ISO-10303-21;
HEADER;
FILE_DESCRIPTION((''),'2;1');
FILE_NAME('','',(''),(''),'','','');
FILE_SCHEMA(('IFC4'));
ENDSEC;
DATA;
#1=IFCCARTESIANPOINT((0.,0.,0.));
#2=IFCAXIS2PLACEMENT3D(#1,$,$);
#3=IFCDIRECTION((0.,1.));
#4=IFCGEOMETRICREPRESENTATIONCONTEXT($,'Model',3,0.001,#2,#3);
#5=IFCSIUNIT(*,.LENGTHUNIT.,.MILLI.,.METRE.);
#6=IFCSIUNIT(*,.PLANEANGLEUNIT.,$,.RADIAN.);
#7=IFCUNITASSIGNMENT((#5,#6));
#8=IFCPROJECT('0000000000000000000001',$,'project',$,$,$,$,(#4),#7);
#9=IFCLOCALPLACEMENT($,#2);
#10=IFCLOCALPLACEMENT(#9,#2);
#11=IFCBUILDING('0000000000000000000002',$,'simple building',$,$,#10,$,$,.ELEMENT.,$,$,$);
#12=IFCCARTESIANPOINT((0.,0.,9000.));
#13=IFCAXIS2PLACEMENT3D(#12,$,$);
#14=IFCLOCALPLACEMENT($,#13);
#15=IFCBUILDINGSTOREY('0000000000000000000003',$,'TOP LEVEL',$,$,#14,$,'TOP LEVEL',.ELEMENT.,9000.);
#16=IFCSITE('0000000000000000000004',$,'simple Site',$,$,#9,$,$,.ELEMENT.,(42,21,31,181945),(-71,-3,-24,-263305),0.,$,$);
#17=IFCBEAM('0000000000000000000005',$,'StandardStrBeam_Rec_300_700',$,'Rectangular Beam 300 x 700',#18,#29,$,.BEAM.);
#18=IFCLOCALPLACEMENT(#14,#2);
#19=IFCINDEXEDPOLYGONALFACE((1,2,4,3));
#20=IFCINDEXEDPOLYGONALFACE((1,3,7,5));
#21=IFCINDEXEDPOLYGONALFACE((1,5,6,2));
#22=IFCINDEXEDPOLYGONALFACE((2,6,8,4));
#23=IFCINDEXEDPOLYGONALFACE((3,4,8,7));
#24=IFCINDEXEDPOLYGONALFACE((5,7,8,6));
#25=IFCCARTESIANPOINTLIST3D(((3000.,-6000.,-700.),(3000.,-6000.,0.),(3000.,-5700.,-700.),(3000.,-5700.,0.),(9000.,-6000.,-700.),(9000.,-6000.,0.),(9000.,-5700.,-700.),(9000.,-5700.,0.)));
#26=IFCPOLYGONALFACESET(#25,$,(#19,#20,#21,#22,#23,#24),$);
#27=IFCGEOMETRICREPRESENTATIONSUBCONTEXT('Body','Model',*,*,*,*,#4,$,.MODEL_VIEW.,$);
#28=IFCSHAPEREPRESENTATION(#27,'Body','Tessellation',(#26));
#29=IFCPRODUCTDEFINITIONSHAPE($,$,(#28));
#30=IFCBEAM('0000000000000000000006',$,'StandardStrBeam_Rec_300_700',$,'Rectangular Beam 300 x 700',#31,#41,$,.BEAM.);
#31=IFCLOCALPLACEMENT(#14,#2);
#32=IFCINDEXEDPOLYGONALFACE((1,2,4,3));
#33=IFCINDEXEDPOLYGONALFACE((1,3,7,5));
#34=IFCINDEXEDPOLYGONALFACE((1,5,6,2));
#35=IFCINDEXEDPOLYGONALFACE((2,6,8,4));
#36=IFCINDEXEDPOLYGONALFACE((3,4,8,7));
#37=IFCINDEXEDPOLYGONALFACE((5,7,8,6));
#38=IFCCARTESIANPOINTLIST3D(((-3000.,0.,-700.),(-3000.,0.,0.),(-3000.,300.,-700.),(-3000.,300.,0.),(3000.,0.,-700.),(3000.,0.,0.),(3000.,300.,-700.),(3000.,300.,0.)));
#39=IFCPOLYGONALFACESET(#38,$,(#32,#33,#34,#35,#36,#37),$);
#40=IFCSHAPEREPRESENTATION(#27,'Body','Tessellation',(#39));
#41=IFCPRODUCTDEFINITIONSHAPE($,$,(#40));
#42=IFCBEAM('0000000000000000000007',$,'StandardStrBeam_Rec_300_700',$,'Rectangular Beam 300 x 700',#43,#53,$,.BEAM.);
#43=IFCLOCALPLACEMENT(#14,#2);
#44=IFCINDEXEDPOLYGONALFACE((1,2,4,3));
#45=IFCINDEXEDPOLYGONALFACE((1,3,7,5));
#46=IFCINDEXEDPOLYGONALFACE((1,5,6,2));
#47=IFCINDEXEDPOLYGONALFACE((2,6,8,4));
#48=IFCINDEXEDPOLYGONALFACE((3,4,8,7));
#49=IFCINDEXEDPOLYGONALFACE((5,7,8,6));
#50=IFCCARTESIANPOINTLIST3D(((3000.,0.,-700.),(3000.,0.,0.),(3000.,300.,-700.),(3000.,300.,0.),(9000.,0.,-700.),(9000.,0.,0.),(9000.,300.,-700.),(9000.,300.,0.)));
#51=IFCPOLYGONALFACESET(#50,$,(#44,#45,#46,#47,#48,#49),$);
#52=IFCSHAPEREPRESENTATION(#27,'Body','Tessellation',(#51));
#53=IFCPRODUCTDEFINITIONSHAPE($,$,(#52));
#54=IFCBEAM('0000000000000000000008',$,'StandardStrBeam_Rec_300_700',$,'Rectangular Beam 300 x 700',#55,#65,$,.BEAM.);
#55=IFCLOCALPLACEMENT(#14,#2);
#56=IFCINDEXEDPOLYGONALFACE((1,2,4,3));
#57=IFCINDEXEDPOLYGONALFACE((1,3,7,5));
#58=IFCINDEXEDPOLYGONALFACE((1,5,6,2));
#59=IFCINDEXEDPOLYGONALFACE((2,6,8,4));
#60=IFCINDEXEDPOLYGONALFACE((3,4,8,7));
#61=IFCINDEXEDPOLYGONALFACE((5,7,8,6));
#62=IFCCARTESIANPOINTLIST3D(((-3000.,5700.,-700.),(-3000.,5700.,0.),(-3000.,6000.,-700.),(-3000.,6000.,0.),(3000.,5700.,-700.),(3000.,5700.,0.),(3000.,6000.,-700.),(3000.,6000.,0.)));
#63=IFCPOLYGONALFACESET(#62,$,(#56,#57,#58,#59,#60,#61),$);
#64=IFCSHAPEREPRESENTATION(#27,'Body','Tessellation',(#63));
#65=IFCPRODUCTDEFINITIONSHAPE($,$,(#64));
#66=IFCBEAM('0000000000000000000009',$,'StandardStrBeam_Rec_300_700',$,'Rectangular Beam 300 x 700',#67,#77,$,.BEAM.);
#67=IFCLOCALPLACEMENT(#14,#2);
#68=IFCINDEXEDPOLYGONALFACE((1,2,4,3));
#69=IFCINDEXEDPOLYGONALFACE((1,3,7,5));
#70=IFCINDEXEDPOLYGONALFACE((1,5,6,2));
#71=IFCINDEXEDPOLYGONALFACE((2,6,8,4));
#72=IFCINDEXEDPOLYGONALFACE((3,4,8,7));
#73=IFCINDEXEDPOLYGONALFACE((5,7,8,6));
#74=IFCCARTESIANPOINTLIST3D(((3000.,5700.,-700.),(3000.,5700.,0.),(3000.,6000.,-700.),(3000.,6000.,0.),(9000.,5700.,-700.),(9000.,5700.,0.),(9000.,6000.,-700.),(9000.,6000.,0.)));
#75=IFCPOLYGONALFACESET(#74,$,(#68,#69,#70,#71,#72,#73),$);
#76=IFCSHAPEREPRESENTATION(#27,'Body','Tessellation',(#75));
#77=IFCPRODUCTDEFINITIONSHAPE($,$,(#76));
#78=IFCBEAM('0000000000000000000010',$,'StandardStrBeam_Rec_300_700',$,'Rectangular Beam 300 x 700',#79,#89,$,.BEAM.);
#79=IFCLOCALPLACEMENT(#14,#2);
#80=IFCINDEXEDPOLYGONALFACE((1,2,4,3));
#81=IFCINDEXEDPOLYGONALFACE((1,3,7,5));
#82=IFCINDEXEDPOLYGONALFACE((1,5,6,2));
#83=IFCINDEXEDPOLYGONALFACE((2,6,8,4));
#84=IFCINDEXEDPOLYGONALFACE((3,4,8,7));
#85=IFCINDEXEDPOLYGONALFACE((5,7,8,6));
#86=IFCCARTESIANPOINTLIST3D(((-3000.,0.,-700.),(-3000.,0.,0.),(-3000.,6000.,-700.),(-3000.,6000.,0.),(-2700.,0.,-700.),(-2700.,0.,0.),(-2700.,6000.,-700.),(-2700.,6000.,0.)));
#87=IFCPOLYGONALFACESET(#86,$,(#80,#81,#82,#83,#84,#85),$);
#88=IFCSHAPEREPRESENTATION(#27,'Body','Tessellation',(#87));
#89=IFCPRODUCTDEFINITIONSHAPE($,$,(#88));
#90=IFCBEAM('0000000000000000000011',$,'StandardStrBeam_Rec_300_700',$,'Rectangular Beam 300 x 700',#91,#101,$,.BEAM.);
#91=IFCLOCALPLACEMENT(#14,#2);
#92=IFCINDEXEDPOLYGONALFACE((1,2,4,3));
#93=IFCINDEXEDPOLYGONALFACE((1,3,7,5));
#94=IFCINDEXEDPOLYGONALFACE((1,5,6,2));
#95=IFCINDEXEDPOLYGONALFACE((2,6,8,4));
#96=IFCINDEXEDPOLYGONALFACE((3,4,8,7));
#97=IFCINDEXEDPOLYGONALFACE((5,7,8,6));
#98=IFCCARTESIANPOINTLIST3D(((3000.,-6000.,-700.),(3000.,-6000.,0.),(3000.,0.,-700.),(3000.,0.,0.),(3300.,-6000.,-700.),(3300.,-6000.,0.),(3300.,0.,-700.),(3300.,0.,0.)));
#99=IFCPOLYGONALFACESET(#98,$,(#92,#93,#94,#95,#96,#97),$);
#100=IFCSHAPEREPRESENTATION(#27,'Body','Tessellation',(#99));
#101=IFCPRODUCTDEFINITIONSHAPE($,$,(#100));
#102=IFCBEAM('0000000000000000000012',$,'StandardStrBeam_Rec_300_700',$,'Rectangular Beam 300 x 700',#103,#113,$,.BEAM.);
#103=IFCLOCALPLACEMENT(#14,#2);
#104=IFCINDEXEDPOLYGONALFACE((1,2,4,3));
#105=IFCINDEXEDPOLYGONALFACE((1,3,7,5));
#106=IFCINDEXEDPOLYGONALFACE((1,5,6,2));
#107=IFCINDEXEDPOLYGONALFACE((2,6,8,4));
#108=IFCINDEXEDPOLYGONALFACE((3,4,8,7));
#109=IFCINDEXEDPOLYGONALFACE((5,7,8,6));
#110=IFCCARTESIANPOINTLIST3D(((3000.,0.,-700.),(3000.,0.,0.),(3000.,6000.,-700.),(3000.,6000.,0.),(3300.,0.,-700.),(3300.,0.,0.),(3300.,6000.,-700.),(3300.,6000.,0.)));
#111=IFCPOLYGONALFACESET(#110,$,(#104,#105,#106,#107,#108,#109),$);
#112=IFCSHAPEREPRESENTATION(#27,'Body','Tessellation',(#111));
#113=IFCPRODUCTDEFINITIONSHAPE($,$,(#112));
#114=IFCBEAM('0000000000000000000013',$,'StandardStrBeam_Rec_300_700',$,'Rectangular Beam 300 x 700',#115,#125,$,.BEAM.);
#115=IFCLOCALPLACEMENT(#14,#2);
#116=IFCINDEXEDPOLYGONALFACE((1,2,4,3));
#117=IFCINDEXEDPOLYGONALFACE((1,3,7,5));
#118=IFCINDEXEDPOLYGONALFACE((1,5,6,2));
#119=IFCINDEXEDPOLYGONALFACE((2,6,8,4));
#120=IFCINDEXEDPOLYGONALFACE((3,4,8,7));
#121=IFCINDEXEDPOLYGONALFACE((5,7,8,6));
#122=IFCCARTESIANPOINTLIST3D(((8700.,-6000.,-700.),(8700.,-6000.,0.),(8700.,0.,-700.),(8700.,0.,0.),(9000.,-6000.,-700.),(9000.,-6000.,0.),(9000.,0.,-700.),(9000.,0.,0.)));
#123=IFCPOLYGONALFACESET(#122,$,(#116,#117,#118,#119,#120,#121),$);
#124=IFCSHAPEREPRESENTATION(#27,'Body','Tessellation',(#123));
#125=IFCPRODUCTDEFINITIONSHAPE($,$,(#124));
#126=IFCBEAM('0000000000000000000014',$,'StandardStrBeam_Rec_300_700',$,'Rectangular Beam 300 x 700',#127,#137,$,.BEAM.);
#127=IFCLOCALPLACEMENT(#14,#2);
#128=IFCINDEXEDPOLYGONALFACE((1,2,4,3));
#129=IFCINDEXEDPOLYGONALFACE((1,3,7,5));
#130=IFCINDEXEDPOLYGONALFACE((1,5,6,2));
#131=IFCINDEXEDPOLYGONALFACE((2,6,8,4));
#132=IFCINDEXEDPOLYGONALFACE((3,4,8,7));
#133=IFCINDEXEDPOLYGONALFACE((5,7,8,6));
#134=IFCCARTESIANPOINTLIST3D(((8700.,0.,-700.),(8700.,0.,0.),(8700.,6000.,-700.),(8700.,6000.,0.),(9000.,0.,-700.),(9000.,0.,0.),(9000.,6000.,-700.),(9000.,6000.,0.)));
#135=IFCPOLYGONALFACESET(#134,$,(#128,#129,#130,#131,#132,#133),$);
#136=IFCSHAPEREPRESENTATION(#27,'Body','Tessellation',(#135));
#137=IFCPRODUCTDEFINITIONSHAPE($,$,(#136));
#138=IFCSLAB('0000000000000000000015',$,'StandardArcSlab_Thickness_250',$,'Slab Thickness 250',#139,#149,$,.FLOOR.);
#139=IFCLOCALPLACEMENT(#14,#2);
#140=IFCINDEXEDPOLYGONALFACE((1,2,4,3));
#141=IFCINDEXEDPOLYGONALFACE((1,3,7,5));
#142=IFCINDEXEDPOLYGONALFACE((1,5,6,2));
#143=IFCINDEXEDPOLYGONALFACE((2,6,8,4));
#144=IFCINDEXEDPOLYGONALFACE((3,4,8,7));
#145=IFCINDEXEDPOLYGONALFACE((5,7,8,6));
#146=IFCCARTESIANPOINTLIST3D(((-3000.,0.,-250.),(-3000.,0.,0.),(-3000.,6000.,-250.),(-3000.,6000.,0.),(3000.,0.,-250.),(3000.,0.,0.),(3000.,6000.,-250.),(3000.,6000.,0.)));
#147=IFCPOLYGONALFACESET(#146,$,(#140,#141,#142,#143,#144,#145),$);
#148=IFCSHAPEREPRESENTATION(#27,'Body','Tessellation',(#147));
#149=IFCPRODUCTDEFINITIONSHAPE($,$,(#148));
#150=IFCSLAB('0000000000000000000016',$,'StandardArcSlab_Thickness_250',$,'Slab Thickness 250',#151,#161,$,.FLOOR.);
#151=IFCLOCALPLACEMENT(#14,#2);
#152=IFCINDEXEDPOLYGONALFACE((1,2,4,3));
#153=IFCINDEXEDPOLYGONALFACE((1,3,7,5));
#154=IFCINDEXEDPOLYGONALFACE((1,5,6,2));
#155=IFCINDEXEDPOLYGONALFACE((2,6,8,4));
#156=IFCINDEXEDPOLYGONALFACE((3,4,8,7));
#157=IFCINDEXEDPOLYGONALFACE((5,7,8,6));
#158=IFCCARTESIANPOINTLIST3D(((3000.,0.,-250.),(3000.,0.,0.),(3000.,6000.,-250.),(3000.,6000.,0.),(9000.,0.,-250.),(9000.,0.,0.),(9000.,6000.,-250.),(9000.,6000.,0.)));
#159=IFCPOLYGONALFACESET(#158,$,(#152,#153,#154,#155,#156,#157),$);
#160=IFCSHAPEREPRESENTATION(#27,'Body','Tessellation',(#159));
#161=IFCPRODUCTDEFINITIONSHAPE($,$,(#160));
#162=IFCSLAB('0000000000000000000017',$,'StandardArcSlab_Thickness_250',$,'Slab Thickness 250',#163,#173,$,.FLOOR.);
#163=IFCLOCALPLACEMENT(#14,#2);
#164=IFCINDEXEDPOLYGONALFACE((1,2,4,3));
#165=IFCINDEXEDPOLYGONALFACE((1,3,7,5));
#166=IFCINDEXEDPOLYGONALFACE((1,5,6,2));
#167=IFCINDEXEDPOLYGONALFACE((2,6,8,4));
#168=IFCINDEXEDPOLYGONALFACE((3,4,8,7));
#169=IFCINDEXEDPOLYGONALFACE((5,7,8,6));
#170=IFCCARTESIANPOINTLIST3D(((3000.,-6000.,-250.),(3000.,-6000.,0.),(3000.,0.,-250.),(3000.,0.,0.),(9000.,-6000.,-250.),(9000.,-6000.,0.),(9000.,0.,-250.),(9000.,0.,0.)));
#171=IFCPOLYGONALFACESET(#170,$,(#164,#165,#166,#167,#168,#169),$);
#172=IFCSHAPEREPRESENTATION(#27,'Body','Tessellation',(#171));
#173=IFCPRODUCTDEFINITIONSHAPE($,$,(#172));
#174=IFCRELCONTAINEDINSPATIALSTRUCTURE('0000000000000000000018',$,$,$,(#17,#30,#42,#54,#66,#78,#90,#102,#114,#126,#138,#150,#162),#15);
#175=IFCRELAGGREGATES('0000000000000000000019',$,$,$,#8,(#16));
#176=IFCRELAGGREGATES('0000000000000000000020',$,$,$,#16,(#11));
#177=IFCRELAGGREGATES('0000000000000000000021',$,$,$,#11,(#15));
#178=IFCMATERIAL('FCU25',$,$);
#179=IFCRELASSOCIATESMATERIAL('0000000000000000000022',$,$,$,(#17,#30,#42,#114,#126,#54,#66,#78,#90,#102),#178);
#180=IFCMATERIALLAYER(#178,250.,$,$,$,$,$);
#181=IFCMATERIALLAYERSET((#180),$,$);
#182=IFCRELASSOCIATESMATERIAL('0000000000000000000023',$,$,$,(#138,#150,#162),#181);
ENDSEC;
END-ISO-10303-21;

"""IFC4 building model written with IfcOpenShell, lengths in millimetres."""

from ifc_helpers import new_model, si_unit, direction, frame, origin, origin_with_axes, origin_2d_with_axis, place, context, subcontext, project, spatial, polyline, rectangle, outline, extrude, material, layer, layer_set, layer_usage, material_profile, profile_set, profile_usage, element, save


model = new_model("IFC4")

# Units and contexts
model_context = context("Model", 3, precision=0.001, world=origin(), true_north=direction((0.0, 1.0)))
body_context = subcontext(model_context, "Body", "Model", "MODEL_VIEW")
ifc_project = project(units=[si_unit("LENGTHUNIT", "METRE", prefix="MILLI"), si_unit("PLANEANGLEUNIT", "RADIAN")], contexts=[model_context])

# Site, building, storey
site_placement = place(None, origin())
site = spatial("IfcSite", under=ifc_project, at=site_placement, Name="simple Site", CompositionType="ELEMENT", RefLatitude=(42, 21, 31, 181945), RefLongitude=(-71, -3, -24, -263305), RefElevation=0.0)
building_placement = place(site_placement, origin())
building = spatial("IfcBuilding", under=site, at=building_placement, Name="simple building", CompositionType="ELEMENT")
storey_placement = place(None, frame((0.0, 0.0, 9000.0)))
storey = spatial("IfcBuildingStorey", under=building, at=storey_placement, Name="TOP LEVEL", LongName="TOP LEVEL", CompositionType="ELEMENT", Elevation=9000.0)

# Beams
ifc_material = material(Name="FCU25")
ifc_material_profile = material_profile(ifc_material, rectangle(XDim=300.0, YDim=700.0, at=origin_2d_with_axis()))
ifc_profile_set = profile_set([ifc_material_profile])
ifc_profile_usage_1 = profile_usage(ifc_profile_set, cardinal=9)
for number, where, z_axis, x_axis, name in (
    (1, (3000.0, -5850.0, 8650.0), (1.0, 0.0, 0.0), (0.0, -1.0, 0.0), "StandardStrBeam_Rec_300_700"),
    (2, (-3000.0, 150.0, 8650.0), (1.0, 0.0, 0.0), (0.0, -1.0, 0.0), "StandardStrBeam_Rec_300_700"),
    (3, (3000.0, 150.0, 8650.0), (1.0, 0.0, 0.0), (0.0, -1.0, 0.0), "StandardStrBeam_Rec_300_700"),
):
    element("IfcBeam", number, at=place(None, frame(where, z_axis=z_axis, x_axis=x_axis)), inside=storey, material=ifc_profile_usage_1, Name=name, ObjectType="Rectangular Beam 300 x 700", PredefinedType="BEAM", context=body_context, shape_type="SweptSolid", body=[
        extrude(rectangle(XDim=300.0, YDim=700.0, at=origin_2d_with_axis()), origin_with_axes(), (0.0, 0.0, 1.0), 6000.0),
    ])
ifc_profile_usage_2 = profile_usage(ifc_profile_set, cardinal=7)
for number, where, z_axis, x_axis, name in (
    (4, (-3000.0, 5850.0, 8650.0), (1.0, 0.0, 0.0), (0.0, -1.0, 0.0), "StandardStrBeam_Rec_300_700"),
    (5, (3000.0, 5850.0, 8650.0), (1.0, 0.0, 0.0), (0.0, -1.0, 0.0), "StandardStrBeam_Rec_300_700"),
    (6, (-2850.0, 0.0, 8650.0), (0.0, 1.0, 0.0), (1.0, 0.0, 0.0), "StandardStrBeam_Rec_300_700"),
    (7, (3150.0, -6000.0, 8650.0), (0.0, 1.0, 0.0), (1.0, 0.0, 0.0), "StandardStrBeam_Rec_300_700"),
    (8, (3150.0, 0.0, 8650.0), (0.0, 1.0, 0.0), (1.0, 0.0, 0.0), "StandardStrBeam_Rec_300_700"),
):
    element("IfcBeam", number, at=place(None, frame(where, z_axis=z_axis, x_axis=x_axis)), inside=storey, material=ifc_profile_usage_2, Name=name, ObjectType="Rectangular Beam 300 x 700", PredefinedType="BEAM", context=body_context, shape_type="SweptSolid", body=[
        extrude(rectangle(XDim=300.0, YDim=700.0, at=origin_2d_with_axis()), origin_with_axes(), (0.0, 0.0, 1.0), 6000.0),
    ])
for number, where, z_axis, x_axis, name in (
    (9, (8850.0, -6000.0, 8650.0), (0.0, 1.0, 0.0), (1.0, 0.0, 0.0), "StandardStrBeam_Rec_300_700"),
    (10, (8850.0, 0.0, 8650.0), (0.0, 1.0, 0.0), (1.0, 0.0, 0.0), "StandardStrBeam_Rec_300_700"),
):
    element("IfcBeam", number, at=place(None, frame(where, z_axis=z_axis, x_axis=x_axis)), inside=storey, material=ifc_profile_usage_1, Name=name, ObjectType="Rectangular Beam 300 x 700", PredefinedType="BEAM", context=body_context, shape_type="SweptSolid", body=[
        extrude(rectangle(XDim=300.0, YDim=700.0, at=origin_2d_with_axis()), origin_with_axes(), (0.0, 0.0, 1.0), 6000.0),
    ])

# Slabs
ifc_layer = layer(ifc_material, 250.0)
ifc_layer_set = layer_set([ifc_layer])
ifc_layer_usage = layer_usage(ifc_layer_set, "AXIS3", "POSITIVE", -250.0)
for number, where, z_axis, x_axis, name in (
    (11, (-3000.0, 0.0, 8750.0), (0.0, 0.0, 1.0), (1.0, 0.0, 0.0), "StandardArcSlab_Thickness_250"),
    (12, (3000.0, 0.0, 8750.0), (0.0, 0.0, 1.0), (1.0, 0.0, 0.0), "StandardArcSlab_Thickness_250"),
    (13, (3000.0, -6000.0, 8750.0), (0.0, 0.0, 1.0), (1.0, 0.0, 0.0), "StandardArcSlab_Thickness_250"),
):
    element("IfcSlab", number, at=place(None, frame(where, z_axis=z_axis, x_axis=x_axis)), inside=storey, material=ifc_layer_usage, Name=name, ObjectType="Slab Thickness 250", PredefinedType="FLOOR", context=body_context, shape_type="SweptSolid", body=[
        extrude(outline(polyline([(0.0, 0.0), (6000.0, 0.0), (6000.0, 6000.0), (0.0, 6000.0), (0.0, 0.0)])), origin_with_axes(), (0.0, 0.0, 1.0), 250.0),
    ])

save(model, "model.ifc")
